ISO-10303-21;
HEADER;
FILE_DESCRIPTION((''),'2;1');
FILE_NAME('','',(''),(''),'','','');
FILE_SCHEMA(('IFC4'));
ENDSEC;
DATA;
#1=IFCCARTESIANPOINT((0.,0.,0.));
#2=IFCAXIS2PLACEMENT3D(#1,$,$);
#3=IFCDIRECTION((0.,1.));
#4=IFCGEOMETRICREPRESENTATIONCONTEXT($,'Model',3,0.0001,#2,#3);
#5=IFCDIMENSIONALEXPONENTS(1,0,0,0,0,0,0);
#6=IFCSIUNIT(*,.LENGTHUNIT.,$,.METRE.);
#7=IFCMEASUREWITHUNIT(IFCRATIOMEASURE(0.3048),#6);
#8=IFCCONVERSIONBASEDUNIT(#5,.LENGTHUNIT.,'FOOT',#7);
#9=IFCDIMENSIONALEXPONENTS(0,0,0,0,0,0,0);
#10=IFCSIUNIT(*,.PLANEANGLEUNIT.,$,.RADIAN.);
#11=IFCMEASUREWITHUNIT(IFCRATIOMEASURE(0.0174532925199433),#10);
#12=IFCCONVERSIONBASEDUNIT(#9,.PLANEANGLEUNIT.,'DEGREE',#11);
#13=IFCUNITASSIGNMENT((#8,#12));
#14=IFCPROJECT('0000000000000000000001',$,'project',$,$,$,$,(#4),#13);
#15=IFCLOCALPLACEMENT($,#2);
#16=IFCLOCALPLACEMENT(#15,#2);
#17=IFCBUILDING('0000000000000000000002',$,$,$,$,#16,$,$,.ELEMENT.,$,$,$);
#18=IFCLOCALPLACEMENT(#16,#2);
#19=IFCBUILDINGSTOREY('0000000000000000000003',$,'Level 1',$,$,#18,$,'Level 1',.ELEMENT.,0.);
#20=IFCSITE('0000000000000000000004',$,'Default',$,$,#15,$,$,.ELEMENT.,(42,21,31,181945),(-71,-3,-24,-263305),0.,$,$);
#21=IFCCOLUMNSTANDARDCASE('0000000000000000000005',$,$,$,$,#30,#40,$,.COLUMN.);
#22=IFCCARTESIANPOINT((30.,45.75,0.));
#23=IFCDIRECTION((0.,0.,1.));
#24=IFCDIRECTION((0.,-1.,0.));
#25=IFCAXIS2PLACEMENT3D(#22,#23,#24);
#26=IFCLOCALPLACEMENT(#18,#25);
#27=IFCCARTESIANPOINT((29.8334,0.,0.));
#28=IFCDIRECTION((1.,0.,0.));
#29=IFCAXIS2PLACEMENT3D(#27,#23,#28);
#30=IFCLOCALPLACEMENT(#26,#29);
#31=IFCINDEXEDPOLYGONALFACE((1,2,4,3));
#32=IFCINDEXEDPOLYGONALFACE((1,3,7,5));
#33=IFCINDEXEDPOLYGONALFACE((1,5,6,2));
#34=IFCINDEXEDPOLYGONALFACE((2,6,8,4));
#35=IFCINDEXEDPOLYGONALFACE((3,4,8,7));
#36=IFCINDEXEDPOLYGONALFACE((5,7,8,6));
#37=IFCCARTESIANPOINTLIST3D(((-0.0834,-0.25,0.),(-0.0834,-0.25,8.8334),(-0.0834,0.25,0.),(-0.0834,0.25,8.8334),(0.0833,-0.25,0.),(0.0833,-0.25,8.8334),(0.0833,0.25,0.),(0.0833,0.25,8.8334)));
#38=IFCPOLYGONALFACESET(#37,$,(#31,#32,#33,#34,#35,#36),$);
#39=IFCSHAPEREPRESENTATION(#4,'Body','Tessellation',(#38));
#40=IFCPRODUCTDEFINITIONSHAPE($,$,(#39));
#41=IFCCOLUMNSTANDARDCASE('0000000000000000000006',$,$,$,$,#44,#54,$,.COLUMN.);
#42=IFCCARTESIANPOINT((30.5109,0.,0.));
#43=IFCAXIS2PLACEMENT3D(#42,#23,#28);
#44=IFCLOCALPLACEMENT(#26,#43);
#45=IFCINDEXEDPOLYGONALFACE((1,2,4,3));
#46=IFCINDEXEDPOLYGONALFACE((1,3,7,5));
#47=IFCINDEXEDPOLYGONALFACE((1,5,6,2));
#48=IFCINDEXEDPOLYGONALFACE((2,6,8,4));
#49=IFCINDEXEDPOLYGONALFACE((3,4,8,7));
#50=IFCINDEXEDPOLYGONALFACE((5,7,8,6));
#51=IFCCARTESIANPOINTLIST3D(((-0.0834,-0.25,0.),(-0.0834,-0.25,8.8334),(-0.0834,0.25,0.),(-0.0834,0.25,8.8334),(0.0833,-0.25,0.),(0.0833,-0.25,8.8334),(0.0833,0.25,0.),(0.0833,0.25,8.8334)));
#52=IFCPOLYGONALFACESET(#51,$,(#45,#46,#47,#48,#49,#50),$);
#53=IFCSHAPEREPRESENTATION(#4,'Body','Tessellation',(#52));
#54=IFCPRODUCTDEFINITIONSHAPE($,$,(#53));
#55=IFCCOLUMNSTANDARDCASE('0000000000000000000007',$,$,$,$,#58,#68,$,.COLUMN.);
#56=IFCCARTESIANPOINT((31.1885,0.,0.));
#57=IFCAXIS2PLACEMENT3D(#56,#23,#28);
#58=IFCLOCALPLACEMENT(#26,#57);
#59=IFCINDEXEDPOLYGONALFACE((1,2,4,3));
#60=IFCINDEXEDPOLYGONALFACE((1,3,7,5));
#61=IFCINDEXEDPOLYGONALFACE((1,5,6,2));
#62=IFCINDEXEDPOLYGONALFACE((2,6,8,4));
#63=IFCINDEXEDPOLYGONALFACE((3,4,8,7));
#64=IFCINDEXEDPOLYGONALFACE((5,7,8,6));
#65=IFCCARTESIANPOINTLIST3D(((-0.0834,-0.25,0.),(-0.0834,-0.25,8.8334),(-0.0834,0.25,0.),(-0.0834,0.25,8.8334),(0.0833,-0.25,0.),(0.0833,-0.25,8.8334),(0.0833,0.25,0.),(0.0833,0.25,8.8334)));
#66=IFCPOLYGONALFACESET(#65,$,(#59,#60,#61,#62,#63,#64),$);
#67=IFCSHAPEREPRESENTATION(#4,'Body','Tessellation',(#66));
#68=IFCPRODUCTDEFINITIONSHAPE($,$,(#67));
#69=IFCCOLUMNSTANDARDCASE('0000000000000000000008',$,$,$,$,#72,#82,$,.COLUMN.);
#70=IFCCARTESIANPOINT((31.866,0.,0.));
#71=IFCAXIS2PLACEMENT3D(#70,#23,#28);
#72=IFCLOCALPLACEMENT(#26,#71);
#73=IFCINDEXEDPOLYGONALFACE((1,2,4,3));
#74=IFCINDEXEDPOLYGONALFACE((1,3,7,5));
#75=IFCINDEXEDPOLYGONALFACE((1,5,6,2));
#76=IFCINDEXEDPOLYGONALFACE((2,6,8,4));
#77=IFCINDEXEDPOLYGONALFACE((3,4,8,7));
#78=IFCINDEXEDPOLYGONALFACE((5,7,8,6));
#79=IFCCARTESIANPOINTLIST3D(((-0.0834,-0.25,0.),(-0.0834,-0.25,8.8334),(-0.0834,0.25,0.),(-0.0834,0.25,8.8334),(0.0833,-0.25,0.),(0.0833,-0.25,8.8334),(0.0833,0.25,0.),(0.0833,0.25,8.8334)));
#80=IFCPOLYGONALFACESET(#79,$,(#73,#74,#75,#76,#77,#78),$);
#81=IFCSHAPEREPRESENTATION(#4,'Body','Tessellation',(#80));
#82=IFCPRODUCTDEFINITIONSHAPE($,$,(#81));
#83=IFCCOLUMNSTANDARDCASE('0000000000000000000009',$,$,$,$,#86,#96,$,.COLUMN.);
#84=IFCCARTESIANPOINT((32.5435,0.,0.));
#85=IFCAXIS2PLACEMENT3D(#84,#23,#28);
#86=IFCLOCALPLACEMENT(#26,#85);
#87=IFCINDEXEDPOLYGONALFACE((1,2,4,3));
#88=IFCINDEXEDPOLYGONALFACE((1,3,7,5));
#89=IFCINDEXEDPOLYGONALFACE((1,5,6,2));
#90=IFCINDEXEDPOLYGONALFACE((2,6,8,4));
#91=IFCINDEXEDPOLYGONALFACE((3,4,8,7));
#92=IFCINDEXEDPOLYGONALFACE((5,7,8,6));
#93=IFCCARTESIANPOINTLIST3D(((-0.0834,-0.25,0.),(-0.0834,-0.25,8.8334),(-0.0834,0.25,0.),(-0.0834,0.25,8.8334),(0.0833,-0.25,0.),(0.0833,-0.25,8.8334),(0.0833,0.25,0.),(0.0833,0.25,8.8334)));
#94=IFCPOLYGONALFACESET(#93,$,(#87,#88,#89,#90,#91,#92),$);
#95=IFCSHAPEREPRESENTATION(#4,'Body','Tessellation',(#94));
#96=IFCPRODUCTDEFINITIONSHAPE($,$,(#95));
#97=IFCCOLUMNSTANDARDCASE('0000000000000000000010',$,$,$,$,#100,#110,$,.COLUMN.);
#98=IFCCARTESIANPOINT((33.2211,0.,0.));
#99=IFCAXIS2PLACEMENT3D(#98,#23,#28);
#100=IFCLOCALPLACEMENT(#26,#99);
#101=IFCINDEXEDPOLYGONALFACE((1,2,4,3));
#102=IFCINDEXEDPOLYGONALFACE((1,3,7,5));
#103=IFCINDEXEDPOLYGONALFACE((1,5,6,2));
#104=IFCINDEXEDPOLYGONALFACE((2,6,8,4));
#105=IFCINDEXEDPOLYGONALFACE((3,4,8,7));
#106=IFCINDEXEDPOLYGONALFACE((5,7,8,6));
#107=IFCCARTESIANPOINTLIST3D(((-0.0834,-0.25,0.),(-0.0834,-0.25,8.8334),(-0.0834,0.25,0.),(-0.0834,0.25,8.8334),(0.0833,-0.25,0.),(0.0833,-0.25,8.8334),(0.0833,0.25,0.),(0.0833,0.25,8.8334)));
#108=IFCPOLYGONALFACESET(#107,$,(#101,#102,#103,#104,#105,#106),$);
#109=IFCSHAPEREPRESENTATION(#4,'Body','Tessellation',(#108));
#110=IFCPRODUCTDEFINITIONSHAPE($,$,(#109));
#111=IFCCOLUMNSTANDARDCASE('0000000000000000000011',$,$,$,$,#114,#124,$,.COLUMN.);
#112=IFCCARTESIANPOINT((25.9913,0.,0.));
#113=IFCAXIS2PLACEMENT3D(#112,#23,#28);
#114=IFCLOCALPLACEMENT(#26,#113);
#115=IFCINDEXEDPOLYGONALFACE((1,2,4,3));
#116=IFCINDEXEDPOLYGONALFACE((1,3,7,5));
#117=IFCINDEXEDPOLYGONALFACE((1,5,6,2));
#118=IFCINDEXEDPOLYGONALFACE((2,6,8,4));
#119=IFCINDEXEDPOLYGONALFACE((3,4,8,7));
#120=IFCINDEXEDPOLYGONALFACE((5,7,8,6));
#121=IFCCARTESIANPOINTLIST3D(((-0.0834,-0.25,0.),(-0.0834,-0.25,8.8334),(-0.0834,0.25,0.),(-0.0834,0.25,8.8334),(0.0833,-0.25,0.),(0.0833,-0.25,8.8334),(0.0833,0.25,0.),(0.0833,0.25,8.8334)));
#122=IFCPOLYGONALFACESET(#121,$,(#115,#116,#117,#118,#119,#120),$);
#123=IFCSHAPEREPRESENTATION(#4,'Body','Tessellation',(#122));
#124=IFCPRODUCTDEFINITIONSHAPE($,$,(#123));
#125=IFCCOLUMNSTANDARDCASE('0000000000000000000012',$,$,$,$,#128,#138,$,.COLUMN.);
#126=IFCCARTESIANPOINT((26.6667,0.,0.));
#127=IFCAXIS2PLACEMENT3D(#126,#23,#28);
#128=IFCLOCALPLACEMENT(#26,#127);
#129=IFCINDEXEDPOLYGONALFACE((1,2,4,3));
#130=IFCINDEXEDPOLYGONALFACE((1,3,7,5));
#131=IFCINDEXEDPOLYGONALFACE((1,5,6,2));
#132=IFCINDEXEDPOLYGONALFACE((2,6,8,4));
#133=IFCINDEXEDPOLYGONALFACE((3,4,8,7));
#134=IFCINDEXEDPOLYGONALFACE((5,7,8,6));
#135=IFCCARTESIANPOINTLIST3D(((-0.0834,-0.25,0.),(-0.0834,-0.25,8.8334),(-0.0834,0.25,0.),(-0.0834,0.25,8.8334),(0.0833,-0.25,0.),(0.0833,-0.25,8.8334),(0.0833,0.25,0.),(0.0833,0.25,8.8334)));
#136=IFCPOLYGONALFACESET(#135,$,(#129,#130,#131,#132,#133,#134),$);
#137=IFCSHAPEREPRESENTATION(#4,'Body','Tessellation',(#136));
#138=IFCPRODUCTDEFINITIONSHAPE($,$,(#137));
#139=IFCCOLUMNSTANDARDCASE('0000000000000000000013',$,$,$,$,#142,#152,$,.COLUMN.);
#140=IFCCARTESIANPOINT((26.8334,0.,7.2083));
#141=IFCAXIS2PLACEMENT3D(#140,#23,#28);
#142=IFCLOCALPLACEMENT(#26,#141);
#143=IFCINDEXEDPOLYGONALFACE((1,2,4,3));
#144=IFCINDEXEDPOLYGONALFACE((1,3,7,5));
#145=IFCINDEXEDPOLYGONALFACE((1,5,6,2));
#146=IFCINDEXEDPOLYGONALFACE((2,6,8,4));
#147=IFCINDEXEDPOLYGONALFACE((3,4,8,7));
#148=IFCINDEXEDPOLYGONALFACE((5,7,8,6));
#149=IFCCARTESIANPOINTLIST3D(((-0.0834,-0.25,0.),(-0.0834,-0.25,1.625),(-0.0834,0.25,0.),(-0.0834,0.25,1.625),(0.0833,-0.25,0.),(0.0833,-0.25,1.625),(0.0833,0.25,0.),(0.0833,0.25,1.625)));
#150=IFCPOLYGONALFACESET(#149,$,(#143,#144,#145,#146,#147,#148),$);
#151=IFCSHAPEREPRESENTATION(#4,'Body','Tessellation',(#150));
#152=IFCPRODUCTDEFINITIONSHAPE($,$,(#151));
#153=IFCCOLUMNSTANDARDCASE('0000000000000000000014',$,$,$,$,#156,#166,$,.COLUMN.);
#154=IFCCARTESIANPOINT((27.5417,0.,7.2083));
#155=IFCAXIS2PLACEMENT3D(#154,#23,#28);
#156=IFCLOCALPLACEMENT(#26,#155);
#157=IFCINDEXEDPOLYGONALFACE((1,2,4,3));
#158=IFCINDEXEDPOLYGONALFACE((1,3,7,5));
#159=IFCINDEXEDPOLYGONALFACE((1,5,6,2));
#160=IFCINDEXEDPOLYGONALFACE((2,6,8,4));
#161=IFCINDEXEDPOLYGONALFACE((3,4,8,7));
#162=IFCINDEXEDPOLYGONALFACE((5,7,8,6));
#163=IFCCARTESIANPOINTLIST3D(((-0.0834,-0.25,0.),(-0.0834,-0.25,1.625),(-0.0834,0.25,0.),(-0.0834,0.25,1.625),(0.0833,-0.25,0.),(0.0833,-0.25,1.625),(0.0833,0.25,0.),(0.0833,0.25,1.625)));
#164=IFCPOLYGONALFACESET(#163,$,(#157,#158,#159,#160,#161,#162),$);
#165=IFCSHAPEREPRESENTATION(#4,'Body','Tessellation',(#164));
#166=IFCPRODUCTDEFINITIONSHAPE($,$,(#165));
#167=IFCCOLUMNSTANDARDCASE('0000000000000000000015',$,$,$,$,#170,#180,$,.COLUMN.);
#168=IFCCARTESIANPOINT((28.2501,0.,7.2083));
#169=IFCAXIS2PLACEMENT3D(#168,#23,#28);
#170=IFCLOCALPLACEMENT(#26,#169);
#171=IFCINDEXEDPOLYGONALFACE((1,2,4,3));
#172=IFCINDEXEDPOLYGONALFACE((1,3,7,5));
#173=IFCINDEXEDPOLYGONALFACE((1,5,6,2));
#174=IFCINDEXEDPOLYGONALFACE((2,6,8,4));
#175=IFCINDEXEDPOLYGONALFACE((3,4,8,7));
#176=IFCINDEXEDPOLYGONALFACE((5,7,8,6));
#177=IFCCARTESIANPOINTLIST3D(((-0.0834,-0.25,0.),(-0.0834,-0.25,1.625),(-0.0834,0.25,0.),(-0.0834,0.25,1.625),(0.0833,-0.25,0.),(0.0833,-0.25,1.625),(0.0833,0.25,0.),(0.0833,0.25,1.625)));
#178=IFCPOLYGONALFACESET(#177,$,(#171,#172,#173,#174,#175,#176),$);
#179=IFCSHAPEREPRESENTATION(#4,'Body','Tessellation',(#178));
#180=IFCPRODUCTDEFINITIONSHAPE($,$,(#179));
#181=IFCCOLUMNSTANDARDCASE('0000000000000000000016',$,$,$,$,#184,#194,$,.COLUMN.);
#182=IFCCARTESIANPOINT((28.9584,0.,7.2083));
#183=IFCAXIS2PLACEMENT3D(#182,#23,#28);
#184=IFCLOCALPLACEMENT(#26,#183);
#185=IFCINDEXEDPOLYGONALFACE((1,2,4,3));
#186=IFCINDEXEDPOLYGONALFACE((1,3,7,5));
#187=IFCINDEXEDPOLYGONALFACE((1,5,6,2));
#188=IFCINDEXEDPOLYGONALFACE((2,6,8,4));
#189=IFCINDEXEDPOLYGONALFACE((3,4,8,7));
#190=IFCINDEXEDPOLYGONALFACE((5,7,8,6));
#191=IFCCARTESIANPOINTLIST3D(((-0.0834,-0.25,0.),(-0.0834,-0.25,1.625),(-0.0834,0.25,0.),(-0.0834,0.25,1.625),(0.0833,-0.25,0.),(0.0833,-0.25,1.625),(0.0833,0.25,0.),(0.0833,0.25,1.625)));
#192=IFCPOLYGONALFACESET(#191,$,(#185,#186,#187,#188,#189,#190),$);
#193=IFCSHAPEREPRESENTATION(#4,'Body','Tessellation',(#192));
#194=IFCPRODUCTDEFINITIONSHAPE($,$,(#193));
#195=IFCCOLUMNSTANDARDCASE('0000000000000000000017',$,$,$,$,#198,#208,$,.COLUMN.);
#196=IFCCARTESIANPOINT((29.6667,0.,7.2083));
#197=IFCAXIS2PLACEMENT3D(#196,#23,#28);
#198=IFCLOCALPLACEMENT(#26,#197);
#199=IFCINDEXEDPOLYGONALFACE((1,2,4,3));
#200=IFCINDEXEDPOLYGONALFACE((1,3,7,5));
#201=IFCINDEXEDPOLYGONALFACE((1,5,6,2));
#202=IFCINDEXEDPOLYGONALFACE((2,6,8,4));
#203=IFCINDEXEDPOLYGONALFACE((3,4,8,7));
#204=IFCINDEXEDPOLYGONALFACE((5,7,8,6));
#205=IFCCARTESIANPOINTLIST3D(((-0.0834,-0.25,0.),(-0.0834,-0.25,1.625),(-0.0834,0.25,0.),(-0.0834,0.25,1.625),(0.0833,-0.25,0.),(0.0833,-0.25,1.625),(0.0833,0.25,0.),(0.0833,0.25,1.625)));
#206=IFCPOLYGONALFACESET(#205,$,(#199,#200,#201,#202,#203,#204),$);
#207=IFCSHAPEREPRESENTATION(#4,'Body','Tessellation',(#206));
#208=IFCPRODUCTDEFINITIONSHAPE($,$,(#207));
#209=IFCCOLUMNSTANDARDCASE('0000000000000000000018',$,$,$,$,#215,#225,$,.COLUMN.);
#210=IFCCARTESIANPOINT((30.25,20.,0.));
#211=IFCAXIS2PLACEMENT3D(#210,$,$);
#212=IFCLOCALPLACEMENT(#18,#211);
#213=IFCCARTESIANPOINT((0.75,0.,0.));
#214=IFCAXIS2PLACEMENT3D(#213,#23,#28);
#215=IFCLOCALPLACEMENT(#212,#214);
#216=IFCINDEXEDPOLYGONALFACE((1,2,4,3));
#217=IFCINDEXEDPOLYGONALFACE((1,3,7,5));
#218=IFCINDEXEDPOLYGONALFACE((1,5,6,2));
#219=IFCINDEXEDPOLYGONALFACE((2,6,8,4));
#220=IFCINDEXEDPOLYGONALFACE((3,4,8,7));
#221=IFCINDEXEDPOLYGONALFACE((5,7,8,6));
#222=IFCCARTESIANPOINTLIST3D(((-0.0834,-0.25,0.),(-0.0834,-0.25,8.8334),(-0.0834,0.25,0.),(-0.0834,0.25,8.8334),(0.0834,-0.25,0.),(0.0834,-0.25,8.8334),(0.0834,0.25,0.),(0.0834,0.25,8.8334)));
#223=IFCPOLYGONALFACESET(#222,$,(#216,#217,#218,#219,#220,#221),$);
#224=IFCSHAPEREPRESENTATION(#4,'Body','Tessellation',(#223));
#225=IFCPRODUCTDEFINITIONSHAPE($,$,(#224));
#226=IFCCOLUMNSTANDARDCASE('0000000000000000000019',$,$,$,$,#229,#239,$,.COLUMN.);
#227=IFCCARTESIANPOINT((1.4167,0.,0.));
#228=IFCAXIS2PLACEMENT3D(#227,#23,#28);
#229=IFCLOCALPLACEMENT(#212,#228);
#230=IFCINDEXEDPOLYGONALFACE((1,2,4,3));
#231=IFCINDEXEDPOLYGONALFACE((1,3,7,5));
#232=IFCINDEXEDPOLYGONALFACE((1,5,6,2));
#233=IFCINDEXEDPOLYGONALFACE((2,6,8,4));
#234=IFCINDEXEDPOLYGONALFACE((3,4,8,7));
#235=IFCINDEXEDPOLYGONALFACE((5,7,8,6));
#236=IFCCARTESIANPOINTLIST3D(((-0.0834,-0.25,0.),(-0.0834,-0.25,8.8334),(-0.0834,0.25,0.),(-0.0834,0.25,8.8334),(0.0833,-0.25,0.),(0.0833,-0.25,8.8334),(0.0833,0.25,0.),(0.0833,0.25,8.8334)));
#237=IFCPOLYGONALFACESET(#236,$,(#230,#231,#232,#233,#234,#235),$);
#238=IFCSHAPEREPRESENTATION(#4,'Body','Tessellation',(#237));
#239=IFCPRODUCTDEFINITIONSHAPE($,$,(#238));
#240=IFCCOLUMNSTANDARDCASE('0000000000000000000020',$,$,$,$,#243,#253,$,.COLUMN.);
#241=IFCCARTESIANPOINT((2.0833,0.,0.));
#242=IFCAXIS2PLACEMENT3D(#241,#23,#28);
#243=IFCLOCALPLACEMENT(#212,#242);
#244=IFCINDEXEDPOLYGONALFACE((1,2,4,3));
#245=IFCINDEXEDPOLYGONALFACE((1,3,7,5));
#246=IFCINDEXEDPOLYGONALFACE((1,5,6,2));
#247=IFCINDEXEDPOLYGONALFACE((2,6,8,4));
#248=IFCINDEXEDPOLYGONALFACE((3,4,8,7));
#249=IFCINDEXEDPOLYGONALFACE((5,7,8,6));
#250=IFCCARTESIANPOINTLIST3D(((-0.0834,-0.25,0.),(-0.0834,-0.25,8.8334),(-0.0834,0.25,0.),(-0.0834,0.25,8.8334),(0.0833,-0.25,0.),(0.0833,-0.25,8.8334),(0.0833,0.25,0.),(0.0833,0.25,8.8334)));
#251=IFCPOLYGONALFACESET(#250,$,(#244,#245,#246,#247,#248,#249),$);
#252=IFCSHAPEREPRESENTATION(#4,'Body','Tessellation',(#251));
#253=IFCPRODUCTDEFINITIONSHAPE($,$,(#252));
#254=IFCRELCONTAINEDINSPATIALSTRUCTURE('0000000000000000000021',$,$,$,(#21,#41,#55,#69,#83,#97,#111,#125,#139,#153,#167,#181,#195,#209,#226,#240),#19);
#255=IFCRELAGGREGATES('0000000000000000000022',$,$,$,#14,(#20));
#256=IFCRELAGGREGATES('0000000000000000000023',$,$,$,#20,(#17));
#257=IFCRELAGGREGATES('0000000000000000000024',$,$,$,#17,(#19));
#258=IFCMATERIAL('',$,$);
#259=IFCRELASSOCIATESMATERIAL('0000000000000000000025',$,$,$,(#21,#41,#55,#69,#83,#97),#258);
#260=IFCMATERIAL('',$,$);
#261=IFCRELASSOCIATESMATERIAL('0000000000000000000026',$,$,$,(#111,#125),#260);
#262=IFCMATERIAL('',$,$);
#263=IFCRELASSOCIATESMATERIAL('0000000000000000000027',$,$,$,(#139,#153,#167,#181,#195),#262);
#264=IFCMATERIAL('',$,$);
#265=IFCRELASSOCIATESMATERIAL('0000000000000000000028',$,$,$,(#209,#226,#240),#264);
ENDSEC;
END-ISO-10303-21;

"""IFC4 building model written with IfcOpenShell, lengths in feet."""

from ifc_helpers import new_model, entity, si_unit, converted_unit, direction, frame, origin, place, context, project, spatial, rectangle, extrude, material, element, save


model = new_model("IFC4")

# Units and contexts
model_context = context("Model", 3, precision=0.0001, world=origin(), true_north=direction((0.0, 1.0)))
ifc_project = project(units=[converted_unit("LENGTHUNIT", "FOOT", entity("IfcRatioMeasure", 0.3048), si_unit("LENGTHUNIT", "METRE"), dimensions=[1, 0, 0, 0, 0, 0, 0]), converted_unit("PLANEANGLEUNIT", "DEGREE", entity("IfcRatioMeasure", 0.0174532925199433), si_unit("PLANEANGLEUNIT", "RADIAN"), dimensions=[0, 0, 0, 0, 0, 0, 0])], contexts=[model_context])

# Site, building, storey
site_placement = place(None, origin())
site = spatial("IfcSite", under=ifc_project, at=site_placement, Name="Default", CompositionType="ELEMENT", RefLatitude=(42, 21, 31, 181945), RefLongitude=(-71, -3, -24, -263305), RefElevation=0.0)
building_placement = place(site_placement, origin())
building = spatial("IfcBuilding", under=site, at=building_placement, CompositionType="ELEMENT")
storey_placement = place(building_placement, origin())
storey = spatial("IfcBuildingStorey", under=building, at=storey_placement, Name="Level 1", LongName="Level 1", CompositionType="ELEMENT", Elevation=0.0)

# Columns
ifc_material_1 = material(Name="")
placement_1 = place(storey_placement, frame((30.0, 45.75, 0.0), z_axis=(0.0, 0.0, 1.0), x_axis=(0.0, -1.0, 0.0)))
for number, where, z_axis, x_axis in (
    (1, (29.8334, 0.0, 0.0), (0.0, 0.0, 1.0), (1.0, 0.0, 0.0)),
    (2, (30.5109, 0.0, 0.0), (0.0, 0.0, 1.0), (1.0, 0.0, 0.0)),
    (3, (31.1885, 0.0, 0.0), (0.0, 0.0, 1.0), (1.0, 0.0, 0.0)),
    (4, (31.866, 0.0, 0.0), (0.0, 0.0, 1.0), (1.0, 0.0, 0.0)),
    (5, (32.5435, 0.0, 0.0), (0.0, 0.0, 1.0), (1.0, 0.0, 0.0)),
    (6, (33.2211, 0.0, 0.0), (0.0, 0.0, 1.0), (1.0, 0.0, 0.0)),
):
    element("IfcColumnStandardCase", number, at=place(placement_1, frame(where, z_axis=z_axis, x_axis=x_axis)), inside=storey, material=ifc_material_1, PredefinedType="COLUMN", context=model_context, shape_type="SweptSolid", body=[
        extrude(rectangle(XDim=0.1667, YDim=0.5), origin(), (0.0, 0.0, 1.0), 8.8334),
    ])
ifc_material_2 = material(Name="")
for number, where, z_axis, x_axis in (
    (7, (25.9913, 0.0, 0.0), (0.0, 0.0, 1.0), (1.0, 0.0, 0.0)),
    (8, (26.6667, 0.0, 0.0), (0.0, 0.0, 1.0), (1.0, 0.0, 0.0)),
):
    element("IfcColumnStandardCase", number, at=place(placement_1, frame(where, z_axis=z_axis, x_axis=x_axis)), inside=storey, material=ifc_material_2, PredefinedType="COLUMN", context=model_context, shape_type="SweptSolid", body=[
        extrude(rectangle(XDim=0.1667, YDim=0.5), origin(), (0.0, 0.0, 1.0), 8.8334),
    ])
ifc_material_3 = material(Name="")
for number, where, z_axis, x_axis in (
    (9, (26.8334, 0.0, 7.2083), (0.0, 0.0, 1.0), (1.0, 0.0, 0.0)),
    (10, (27.5417, 0.0, 7.2083), (0.0, 0.0, 1.0), (1.0, 0.0, 0.0)),
    (11, (28.2501, 0.0, 7.2083), (0.0, 0.0, 1.0), (1.0, 0.0, 0.0)),
    (12, (28.9584, 0.0, 7.2083), (0.0, 0.0, 1.0), (1.0, 0.0, 0.0)),
    (13, (29.6667, 0.0, 7.2083), (0.0, 0.0, 1.0), (1.0, 0.0, 0.0)),
):
    element("IfcColumnStandardCase", number, at=place(placement_1, frame(where, z_axis=z_axis, x_axis=x_axis)), inside=storey, material=ifc_material_3, PredefinedType="COLUMN", context=model_context, shape_type="SweptSolid", body=[
        extrude(rectangle(XDim=0.1667, YDim=0.5), origin(), (0.0, 0.0, 1.0), 1.625),
    ])
ifc_material_4 = material(Name="")
placement_2 = place(storey_placement, frame((30.25, 20.0, 0.0)))
for number, where, z_axis, x_axis in (
    (14, (0.75, 0.0, 0.0), (0.0, 0.0, 1.0), (1.0, 0.0, 0.0)),
    (15, (1.4167, 0.0, 0.0), (0.0, 0.0, 1.0), (1.0, 0.0, 0.0)),
    (16, (2.0833, 0.0, 0.0), (0.0, 0.0, 1.0), (1.0, 0.0, 0.0)),
):
    element("IfcColumnStandardCase", number, at=place(placement_2, frame(where, z_axis=z_axis, x_axis=x_axis)), inside=storey, material=ifc_material_4, PredefinedType="COLUMN", context=model_context, shape_type="SweptSolid", body=[
        extrude(rectangle(XDim=0.1667, YDim=0.5), origin(), (0.0, 0.0, 1.0), 8.8334),
    ])

save(model, "model.ifc")
